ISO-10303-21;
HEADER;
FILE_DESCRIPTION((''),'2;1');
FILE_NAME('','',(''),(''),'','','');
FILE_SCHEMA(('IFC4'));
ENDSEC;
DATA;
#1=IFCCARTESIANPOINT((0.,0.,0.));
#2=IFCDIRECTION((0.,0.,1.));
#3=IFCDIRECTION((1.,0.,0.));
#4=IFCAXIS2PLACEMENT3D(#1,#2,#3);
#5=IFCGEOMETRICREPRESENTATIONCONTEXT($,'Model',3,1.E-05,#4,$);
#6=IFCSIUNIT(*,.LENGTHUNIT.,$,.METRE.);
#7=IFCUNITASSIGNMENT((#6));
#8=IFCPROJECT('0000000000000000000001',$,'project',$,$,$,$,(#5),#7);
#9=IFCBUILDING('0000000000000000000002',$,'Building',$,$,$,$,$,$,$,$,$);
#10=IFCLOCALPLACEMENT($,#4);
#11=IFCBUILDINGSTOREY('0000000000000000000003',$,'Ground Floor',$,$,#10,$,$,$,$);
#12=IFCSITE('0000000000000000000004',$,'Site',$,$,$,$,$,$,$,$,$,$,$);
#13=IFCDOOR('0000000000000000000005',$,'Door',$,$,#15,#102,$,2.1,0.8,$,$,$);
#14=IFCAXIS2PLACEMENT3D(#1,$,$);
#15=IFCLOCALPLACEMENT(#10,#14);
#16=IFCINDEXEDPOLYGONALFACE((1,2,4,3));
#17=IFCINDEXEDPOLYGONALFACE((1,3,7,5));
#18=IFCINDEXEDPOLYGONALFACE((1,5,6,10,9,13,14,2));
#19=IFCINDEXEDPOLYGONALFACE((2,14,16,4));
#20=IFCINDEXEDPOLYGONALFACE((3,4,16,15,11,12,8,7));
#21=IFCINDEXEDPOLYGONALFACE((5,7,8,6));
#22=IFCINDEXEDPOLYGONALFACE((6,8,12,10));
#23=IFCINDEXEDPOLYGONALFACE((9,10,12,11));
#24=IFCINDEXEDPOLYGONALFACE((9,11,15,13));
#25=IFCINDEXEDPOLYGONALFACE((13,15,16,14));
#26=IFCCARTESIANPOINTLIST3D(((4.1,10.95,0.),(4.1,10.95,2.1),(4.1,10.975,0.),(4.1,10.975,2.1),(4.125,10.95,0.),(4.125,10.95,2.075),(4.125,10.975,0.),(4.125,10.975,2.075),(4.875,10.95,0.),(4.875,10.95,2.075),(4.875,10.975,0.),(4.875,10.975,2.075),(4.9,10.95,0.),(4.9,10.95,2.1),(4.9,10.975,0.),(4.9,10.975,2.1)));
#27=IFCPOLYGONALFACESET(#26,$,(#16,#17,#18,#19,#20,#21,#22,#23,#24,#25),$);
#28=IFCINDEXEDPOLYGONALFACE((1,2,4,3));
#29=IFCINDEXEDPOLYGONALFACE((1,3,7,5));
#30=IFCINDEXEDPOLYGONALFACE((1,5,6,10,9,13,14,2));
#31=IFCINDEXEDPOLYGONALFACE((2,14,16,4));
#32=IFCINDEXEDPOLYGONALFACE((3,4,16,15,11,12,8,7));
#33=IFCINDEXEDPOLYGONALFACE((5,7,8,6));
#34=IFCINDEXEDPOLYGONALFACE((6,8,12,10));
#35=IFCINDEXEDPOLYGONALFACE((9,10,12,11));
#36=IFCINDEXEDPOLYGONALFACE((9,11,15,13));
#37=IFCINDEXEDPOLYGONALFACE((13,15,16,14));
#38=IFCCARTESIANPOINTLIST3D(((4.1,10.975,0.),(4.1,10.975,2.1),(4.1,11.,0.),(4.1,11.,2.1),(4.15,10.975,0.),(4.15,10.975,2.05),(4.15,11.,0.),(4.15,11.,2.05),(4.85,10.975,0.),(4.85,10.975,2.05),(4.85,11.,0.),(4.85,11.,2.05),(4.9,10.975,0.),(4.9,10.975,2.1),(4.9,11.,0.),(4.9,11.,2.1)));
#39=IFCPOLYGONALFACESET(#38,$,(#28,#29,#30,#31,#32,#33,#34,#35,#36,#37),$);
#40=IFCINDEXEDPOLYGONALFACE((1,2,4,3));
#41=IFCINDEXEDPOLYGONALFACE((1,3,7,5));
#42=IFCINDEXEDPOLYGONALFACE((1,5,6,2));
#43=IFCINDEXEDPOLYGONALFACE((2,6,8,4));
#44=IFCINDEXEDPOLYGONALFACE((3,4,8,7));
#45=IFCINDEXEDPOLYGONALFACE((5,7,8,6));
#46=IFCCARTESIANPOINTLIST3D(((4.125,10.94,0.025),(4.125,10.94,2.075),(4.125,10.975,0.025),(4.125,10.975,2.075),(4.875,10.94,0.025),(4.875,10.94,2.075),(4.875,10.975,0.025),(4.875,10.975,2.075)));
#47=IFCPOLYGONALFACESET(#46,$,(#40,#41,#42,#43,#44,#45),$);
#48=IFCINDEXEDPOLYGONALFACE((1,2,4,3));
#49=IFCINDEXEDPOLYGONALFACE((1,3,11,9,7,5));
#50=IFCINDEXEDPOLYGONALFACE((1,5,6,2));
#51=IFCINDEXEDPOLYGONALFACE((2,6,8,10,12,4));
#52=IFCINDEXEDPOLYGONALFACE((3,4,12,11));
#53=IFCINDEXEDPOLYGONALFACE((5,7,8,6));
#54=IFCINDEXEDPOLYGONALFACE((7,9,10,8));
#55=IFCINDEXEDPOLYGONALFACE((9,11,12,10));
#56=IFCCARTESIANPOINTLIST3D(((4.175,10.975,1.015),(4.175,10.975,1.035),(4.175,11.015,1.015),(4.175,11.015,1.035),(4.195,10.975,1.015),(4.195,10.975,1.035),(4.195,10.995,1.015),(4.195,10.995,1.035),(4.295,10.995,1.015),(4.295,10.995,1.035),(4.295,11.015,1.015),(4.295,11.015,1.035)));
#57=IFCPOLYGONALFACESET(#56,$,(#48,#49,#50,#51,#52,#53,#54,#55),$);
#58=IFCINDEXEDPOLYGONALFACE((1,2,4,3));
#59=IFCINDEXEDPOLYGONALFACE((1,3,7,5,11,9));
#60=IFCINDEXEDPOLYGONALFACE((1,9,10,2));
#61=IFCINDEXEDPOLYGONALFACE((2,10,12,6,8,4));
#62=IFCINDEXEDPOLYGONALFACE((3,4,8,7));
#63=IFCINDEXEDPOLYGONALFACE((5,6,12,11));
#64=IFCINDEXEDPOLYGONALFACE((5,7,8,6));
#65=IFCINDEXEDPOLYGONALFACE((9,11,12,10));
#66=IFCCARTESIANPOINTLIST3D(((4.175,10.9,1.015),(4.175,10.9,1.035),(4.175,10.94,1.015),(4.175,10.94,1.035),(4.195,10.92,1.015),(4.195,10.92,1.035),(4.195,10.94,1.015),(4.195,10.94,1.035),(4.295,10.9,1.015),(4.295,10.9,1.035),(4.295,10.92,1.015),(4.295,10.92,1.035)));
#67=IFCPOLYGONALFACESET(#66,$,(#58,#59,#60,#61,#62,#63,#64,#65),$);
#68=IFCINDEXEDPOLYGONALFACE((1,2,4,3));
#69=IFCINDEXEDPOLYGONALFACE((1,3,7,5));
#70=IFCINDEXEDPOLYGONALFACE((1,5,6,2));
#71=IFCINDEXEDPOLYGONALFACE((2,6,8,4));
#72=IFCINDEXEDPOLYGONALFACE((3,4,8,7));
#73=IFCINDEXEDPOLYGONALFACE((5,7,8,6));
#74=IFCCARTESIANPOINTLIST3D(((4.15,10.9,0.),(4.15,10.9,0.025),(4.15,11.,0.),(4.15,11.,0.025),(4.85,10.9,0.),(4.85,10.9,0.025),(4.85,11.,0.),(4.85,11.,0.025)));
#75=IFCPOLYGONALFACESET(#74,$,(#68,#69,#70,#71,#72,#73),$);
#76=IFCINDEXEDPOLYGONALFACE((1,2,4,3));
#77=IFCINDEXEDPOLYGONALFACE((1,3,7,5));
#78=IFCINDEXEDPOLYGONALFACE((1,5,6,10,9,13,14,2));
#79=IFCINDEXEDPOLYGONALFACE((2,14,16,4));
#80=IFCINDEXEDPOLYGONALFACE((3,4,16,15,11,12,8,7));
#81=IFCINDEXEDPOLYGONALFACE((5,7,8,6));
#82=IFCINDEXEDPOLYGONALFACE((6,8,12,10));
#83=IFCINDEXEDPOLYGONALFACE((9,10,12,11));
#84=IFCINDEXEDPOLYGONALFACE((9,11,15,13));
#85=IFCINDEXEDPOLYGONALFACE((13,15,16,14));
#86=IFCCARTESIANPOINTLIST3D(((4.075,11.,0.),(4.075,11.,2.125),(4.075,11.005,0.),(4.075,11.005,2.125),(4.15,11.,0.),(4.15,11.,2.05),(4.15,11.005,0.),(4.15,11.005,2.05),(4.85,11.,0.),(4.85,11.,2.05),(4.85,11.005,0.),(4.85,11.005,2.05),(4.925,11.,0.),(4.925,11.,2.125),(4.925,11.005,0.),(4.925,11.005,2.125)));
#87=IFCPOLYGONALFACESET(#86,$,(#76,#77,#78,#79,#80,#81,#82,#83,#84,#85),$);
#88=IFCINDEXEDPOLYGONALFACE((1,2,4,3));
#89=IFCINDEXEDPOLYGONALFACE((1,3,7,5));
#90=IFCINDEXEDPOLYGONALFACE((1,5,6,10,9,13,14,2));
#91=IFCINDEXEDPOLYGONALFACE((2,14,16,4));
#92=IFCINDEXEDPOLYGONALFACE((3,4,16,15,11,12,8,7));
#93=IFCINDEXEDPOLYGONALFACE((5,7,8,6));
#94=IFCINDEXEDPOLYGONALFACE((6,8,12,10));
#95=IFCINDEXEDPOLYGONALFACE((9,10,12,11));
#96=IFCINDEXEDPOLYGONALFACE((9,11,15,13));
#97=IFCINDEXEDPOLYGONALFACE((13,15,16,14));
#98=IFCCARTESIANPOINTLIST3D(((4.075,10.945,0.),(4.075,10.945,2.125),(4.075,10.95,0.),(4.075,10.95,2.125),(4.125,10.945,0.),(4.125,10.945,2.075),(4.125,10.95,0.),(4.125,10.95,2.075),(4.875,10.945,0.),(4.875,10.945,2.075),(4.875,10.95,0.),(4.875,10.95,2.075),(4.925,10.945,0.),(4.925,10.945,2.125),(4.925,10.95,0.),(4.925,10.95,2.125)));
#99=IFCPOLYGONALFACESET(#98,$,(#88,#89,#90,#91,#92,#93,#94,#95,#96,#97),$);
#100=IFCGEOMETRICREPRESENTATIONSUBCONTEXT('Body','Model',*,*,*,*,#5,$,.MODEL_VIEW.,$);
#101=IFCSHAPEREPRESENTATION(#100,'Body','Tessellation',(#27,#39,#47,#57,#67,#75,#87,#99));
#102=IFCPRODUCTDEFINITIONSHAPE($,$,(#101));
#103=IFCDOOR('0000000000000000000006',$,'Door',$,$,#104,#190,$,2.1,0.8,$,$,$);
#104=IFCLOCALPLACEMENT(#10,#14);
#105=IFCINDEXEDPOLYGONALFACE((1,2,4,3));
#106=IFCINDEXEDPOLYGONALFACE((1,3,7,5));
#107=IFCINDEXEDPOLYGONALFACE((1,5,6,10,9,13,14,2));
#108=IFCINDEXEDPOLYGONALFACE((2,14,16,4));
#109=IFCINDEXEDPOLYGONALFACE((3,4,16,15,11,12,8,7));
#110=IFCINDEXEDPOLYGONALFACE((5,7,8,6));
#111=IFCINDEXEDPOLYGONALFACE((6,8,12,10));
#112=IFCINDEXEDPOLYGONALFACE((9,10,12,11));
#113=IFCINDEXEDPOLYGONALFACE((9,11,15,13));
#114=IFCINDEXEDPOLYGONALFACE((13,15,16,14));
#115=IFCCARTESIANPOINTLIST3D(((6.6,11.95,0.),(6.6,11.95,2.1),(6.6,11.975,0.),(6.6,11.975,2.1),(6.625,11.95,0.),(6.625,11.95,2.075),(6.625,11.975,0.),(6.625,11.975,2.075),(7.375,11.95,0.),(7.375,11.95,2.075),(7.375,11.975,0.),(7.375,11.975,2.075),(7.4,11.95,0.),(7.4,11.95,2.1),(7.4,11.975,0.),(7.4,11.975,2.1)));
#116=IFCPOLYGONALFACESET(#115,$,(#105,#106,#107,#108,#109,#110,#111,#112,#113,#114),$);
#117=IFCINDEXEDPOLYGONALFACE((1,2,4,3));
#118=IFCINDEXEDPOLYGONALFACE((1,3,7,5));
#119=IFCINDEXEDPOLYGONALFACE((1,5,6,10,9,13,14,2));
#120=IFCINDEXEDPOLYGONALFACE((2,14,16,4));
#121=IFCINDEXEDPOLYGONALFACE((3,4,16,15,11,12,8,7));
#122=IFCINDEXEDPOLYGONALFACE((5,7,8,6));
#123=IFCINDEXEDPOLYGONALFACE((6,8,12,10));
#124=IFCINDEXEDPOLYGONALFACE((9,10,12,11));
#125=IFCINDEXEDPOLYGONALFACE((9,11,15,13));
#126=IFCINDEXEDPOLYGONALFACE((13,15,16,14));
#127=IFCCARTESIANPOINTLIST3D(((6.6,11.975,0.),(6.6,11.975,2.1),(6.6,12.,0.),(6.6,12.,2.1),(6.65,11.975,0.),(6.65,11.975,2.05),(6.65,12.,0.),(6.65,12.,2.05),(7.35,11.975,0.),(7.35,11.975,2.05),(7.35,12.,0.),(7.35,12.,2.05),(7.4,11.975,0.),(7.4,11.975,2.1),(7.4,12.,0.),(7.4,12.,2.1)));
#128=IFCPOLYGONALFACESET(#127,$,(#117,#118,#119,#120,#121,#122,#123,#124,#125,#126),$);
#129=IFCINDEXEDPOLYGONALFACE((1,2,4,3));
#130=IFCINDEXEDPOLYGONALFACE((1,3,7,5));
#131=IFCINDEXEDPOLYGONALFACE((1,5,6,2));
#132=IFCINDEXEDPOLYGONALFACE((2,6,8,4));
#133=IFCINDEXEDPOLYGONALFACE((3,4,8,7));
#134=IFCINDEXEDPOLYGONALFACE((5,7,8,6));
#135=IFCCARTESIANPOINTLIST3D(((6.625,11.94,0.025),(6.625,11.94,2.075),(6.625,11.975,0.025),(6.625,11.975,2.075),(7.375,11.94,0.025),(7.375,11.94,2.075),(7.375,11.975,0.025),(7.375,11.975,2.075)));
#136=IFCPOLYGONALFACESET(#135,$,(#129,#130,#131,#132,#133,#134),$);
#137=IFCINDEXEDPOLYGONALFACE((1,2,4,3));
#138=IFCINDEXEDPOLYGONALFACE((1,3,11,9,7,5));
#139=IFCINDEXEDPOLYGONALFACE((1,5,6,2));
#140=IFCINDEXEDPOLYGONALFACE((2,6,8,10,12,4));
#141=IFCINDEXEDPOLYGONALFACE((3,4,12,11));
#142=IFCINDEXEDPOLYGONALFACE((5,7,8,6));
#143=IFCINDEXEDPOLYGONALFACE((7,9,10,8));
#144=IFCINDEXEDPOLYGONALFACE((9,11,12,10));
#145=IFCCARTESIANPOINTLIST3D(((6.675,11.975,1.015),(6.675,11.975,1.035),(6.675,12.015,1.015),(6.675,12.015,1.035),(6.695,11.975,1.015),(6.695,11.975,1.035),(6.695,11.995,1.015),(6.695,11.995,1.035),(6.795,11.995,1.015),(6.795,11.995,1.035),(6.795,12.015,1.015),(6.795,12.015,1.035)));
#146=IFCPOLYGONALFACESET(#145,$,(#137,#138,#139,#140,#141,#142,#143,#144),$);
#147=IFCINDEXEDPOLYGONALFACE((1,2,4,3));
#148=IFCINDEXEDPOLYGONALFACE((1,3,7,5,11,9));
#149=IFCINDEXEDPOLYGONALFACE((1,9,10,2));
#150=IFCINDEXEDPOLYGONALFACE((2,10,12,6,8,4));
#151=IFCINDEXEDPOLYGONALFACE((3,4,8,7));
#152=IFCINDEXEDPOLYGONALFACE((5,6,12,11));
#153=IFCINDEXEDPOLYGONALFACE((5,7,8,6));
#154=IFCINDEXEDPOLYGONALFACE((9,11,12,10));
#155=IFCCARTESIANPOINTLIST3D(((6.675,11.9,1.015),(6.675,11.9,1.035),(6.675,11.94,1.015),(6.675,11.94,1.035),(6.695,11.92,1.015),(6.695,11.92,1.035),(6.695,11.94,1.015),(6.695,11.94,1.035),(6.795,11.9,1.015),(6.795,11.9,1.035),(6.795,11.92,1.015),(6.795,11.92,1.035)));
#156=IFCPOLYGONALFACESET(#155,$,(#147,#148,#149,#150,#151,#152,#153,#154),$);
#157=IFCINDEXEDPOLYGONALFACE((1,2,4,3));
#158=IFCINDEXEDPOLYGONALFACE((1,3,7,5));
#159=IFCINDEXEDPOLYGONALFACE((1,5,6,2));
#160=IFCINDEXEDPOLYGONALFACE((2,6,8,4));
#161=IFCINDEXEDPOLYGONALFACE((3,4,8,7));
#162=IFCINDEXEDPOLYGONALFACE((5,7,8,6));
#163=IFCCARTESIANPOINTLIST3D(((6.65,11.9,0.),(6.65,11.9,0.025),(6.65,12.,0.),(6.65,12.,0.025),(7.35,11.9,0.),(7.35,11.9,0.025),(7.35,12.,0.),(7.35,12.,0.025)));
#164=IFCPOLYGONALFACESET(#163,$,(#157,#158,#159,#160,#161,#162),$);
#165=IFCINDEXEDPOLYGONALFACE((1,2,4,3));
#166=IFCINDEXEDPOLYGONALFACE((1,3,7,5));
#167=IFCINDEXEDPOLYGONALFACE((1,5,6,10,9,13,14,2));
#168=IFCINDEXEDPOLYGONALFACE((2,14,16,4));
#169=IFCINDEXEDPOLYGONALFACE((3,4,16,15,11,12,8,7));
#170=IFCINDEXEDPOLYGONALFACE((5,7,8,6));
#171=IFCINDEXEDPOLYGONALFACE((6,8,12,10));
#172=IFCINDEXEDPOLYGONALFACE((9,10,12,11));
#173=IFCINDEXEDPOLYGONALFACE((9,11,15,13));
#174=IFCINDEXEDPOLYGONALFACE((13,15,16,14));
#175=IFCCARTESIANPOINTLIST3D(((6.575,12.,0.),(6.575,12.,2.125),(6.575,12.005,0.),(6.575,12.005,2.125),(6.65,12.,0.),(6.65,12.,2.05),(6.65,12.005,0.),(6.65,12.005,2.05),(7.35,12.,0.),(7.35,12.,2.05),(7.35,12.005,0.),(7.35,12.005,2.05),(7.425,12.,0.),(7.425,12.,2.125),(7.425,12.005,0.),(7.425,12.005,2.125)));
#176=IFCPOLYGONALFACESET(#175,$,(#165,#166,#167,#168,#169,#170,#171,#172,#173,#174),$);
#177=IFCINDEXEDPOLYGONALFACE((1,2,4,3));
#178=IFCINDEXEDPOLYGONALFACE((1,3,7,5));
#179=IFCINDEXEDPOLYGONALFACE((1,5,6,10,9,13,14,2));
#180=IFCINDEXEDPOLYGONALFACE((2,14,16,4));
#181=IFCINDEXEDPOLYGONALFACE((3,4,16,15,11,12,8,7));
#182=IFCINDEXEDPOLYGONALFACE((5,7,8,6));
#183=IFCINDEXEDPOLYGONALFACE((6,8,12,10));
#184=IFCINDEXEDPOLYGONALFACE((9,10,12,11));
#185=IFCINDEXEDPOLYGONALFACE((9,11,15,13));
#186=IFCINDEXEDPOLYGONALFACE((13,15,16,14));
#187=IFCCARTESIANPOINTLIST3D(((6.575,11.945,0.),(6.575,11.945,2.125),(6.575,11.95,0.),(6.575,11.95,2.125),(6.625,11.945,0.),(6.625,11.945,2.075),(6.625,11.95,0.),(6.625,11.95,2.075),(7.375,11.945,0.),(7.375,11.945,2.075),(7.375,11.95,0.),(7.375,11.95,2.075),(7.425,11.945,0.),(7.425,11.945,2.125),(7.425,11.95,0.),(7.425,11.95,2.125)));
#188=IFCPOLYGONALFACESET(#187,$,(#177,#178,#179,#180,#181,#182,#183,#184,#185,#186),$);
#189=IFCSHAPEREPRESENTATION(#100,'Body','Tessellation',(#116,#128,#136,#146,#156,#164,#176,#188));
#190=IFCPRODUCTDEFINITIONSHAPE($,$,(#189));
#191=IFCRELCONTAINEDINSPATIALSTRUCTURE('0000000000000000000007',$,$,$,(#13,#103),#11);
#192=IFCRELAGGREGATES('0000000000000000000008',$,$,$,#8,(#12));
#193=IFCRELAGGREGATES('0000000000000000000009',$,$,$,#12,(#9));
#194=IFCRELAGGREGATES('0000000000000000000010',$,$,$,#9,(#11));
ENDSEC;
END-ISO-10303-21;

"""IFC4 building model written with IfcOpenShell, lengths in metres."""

from ifc_helpers import new_model, si_unit, frame, origin_with_axes, place, context, subcontext, project, spatial, line, indexed_curve, outline, extrude, element, save


model = new_model("IFC4")

# Units and contexts
model_context = context("Model", 3, precision=1e-05, world=origin_with_axes())
body_context = subcontext(model_context, "Body", "Model", "MODEL_VIEW")
ifc_project = project(units=[si_unit("LENGTHUNIT", "METRE")], contexts=[model_context])

# Site, building, storey
site = spatial("IfcSite", under=ifc_project, Name="Site")
building = spatial("IfcBuilding", under=site, Name="Building")
storey_placement = place(None, origin_with_axes())
storey = spatial("IfcBuildingStorey", under=building, at=storey_placement, Name="Ground Floor")

# Doors
door_1_placement = place(storey_placement, frame((4.9, 11.0, 0.0), z_axis=(0.0, 0.0, 1.0), x_axis=(-1.0, 0.0, 0.0)))
element("IfcDoor", 1, at=door_1_placement, inside=storey, Name="Door", OverallHeight=2.1, OverallWidth=0.8, context=body_context, shape_type="SweptSolid", body=[
    extrude(outline(indexed_curve([(0.0, 0.0), (0.0, 2.1), (0.8, 2.1), (0.8, 0.0), (0.775, 0.0), (0.775, 2.075), (0.025, 2.075), (0.025, 0.0)], segments=[line(1, 2, 3, 4, 5, 6, 7, 8, 1)])), frame((0.0, 0.025, 0.0), z_axis=(0.0, -1.0, 0.0), x_axis=(1.0, 0.0, 0.0)), (0.0, 0.0, -1.0), 0.025),
    extrude(outline(indexed_curve([(0.0, 0.0), (0.0, 2.1), (0.8, 2.1), (0.8, 0.0), (0.75, 0.0), (0.75, 2.05), (0.05, 2.05), (0.05, 0.0)], segments=[line(1, 2, 3, 4, 5, 6, 7, 8, 1)])), frame((0.0, 0.0, 0.0), z_axis=(0.0, -1.0, 0.0), x_axis=(1.0, 0.0, 0.0)), (0.0, 0.0, -1.0), 0.025),
    extrude(outline(indexed_curve([(0.0, 0.0), (0.75, 0.0), (0.75, 0.035), (0.0, 0.035)], segments=[line(1, 2, 3, 4, 1)])), frame((0.025, 0.025, 0.025), z_axis=(0.0, 0.0, 1.0), x_axis=(1.0, 0.0, 0.0)), (0.0, 0.0, 1.0), 2.05),
    extrude(outline(indexed_curve([(0.0, 0.0), (0.0, -0.04), (-0.12, -0.04), (-0.12, -0.02), (-0.02, -0.02), (-0.02, 0.0)], segments=[line(1, 2, 3, 4, 5, 6, 1)])), frame((0.725, 0.025, 1.015), z_axis=(0.0, 0.0, 1.0), x_axis=(1.0, 0.0, 0.0)), (0.0, 0.0, 1.0), 0.02),
    extrude(outline(indexed_curve([(0.0, 0.0), (0.0, 0.04), (-0.12, 0.04), (-0.12, 0.02), (-0.02, 0.02), (-0.02, 0.0)], segments=[line(1, 2, 3, 4, 5, 6, 1)])), frame((0.725, 0.06, 1.015), z_axis=(0.0, 0.0, 1.0), x_axis=(1.0, 0.0, 0.0)), (0.0, 0.0, 1.0), 0.02),
    extrude(outline(indexed_curve([(0.0, 0.0), (0.7, 0.0), (0.7, 0.1), (0.0, 0.1)], segments=[line(1, 2, 3, 4, 1)])), frame((0.05, 0.0, 0.0), z_axis=(0.0, 0.0, 1.0), x_axis=(1.0, 0.0, 0.0)), (0.0, 0.0, 1.0), 0.025),
    extrude(outline(indexed_curve([(0.0, 0.0), (0.0, 2.125), (0.85, 2.125), (0.85, 0.0), (0.775, 0.0), (0.775, 2.05), (0.075, 2.05), (0.075, 0.0)], segments=[line(1, 2, 3, 4, 5, 6, 7, 8, 1)])), frame((-0.025, -0.005, 0.0), z_axis=(0.0, -1.0, 0.0), x_axis=(1.0, 0.0, 0.0)), (0.0, 0.0, -1.0), 0.005),
    extrude(outline(indexed_curve([(0.0, 0.0), (0.0, 2.125), (0.85, 2.125), (0.85, 0.0), (0.8, 0.0), (0.8, 2.075), (0.05, 2.075), (0.05, 0.0)], segments=[line(1, 2, 3, 4, 5, 6, 7, 8, 1)])), frame((-0.025, 0.05, 0.0), z_axis=(0.0, -1.0, 0.0), x_axis=(1.0, 0.0, 0.0)), (0.0, 0.0, -1.0), 0.005),
])
door_2_placement = place(storey_placement, frame((7.4, 12.0, 0.0), z_axis=(0.0, 0.0, 1.0), x_axis=(-1.0, 0.0, 0.0)))
element("IfcDoor", 2, at=door_2_placement, inside=storey, Name="Door", OverallHeight=2.1, OverallWidth=0.8, context=body_context, shape_type="SweptSolid", body=[
    extrude(outline(indexed_curve([(0.0, 0.0), (0.0, 2.1), (0.8, 2.1), (0.8, 0.0), (0.775, 0.0), (0.775, 2.075), (0.025, 2.075), (0.025, 0.0)], segments=[line(1, 2, 3, 4, 5, 6, 7, 8, 1)])), frame((0.0, 0.025, 0.0), z_axis=(0.0, -1.0, 0.0), x_axis=(1.0, 0.0, 0.0)), (0.0, 0.0, -1.0), 0.025),
    extrude(outline(indexed_curve([(0.0, 0.0), (0.0, 2.1), (0.8, 2.1), (0.8, 0.0), (0.75, 0.0), (0.75, 2.05), (0.05, 2.05), (0.05, 0.0)], segments=[line(1, 2, 3, 4, 5, 6, 7, 8, 1)])), frame((0.0, 0.0, 0.0), z_axis=(0.0, -1.0, 0.0), x_axis=(1.0, 0.0, 0.0)), (0.0, 0.0, -1.0), 0.025),
    extrude(outline(indexed_curve([(0.0, 0.0), (0.75, 0.0), (0.75, 0.035), (0.0, 0.035)], segments=[line(1, 2, 3, 4, 1)])), frame((0.025, 0.025, 0.025), z_axis=(0.0, 0.0, 1.0), x_axis=(1.0, 0.0, 0.0)), (0.0, 0.0, 1.0), 2.05),
    extrude(outline(indexed_curve([(0.0, 0.0), (0.0, -0.04), (-0.12, -0.04), (-0.12, -0.02), (-0.02, -0.02), (-0.02, 0.0)], segments=[line(1, 2, 3, 4, 5, 6, 1)])), frame((0.725, 0.025, 1.015), z_axis=(0.0, 0.0, 1.0), x_axis=(1.0, 0.0, 0.0)), (0.0, 0.0, 1.0), 0.02),
    extrude(outline(indexed_curve([(0.0, 0.0), (0.0, 0.04), (-0.12, 0.04), (-0.12, 0.02), (-0.02, 0.02), (-0.02, 0.0)], segments=[line(1, 2, 3, 4, 5, 6, 1)])), frame((0.725, 0.06, 1.015), z_axis=(0.0, 0.0, 1.0), x_axis=(1.0, 0.0, 0.0)), (0.0, 0.0, 1.0), 0.02),
    extrude(outline(indexed_curve([(0.0, 0.0), (0.7, 0.0), (0.7, 0.1), (0.0, 0.1)], segments=[line(1, 2, 3, 4, 1)])), frame((0.05, 0.0, 0.0), z_axis=(0.0, 0.0, 1.0), x_axis=(1.0, 0.0, 0.0)), (0.0, 0.0, 1.0), 0.025),
    extrude(outline(indexed_curve([(0.0, 0.0), (0.0, 2.125), (0.85, 2.125), (0.85, 0.0), (0.775, 0.0), (0.775, 2.05), (0.075, 2.05), (0.075, 0.0)], segments=[line(1, 2, 3, 4, 5, 6, 7, 8, 1)])), frame((-0.025, -0.005, 0.0), z_axis=(0.0, -1.0, 0.0), x_axis=(1.0, 0.0, 0.0)), (0.0, 0.0, -1.0), 0.005),
    extrude(outline(indexed_curve([(0.0, 0.0), (0.0, 2.125), (0.85, 2.125), (0.85, 0.0), (0.8, 0.0), (0.8, 2.075), (0.05, 2.075), (0.05, 0.0)], segments=[line(1, 2, 3, 4, 5, 6, 7, 8, 1)])), frame((-0.025, 0.05, 0.0), z_axis=(0.0, -1.0, 0.0), x_axis=(1.0, 0.0, 0.0)), (0.0, 0.0, -1.0), 0.005),
])

save(model, "model.ifc")
